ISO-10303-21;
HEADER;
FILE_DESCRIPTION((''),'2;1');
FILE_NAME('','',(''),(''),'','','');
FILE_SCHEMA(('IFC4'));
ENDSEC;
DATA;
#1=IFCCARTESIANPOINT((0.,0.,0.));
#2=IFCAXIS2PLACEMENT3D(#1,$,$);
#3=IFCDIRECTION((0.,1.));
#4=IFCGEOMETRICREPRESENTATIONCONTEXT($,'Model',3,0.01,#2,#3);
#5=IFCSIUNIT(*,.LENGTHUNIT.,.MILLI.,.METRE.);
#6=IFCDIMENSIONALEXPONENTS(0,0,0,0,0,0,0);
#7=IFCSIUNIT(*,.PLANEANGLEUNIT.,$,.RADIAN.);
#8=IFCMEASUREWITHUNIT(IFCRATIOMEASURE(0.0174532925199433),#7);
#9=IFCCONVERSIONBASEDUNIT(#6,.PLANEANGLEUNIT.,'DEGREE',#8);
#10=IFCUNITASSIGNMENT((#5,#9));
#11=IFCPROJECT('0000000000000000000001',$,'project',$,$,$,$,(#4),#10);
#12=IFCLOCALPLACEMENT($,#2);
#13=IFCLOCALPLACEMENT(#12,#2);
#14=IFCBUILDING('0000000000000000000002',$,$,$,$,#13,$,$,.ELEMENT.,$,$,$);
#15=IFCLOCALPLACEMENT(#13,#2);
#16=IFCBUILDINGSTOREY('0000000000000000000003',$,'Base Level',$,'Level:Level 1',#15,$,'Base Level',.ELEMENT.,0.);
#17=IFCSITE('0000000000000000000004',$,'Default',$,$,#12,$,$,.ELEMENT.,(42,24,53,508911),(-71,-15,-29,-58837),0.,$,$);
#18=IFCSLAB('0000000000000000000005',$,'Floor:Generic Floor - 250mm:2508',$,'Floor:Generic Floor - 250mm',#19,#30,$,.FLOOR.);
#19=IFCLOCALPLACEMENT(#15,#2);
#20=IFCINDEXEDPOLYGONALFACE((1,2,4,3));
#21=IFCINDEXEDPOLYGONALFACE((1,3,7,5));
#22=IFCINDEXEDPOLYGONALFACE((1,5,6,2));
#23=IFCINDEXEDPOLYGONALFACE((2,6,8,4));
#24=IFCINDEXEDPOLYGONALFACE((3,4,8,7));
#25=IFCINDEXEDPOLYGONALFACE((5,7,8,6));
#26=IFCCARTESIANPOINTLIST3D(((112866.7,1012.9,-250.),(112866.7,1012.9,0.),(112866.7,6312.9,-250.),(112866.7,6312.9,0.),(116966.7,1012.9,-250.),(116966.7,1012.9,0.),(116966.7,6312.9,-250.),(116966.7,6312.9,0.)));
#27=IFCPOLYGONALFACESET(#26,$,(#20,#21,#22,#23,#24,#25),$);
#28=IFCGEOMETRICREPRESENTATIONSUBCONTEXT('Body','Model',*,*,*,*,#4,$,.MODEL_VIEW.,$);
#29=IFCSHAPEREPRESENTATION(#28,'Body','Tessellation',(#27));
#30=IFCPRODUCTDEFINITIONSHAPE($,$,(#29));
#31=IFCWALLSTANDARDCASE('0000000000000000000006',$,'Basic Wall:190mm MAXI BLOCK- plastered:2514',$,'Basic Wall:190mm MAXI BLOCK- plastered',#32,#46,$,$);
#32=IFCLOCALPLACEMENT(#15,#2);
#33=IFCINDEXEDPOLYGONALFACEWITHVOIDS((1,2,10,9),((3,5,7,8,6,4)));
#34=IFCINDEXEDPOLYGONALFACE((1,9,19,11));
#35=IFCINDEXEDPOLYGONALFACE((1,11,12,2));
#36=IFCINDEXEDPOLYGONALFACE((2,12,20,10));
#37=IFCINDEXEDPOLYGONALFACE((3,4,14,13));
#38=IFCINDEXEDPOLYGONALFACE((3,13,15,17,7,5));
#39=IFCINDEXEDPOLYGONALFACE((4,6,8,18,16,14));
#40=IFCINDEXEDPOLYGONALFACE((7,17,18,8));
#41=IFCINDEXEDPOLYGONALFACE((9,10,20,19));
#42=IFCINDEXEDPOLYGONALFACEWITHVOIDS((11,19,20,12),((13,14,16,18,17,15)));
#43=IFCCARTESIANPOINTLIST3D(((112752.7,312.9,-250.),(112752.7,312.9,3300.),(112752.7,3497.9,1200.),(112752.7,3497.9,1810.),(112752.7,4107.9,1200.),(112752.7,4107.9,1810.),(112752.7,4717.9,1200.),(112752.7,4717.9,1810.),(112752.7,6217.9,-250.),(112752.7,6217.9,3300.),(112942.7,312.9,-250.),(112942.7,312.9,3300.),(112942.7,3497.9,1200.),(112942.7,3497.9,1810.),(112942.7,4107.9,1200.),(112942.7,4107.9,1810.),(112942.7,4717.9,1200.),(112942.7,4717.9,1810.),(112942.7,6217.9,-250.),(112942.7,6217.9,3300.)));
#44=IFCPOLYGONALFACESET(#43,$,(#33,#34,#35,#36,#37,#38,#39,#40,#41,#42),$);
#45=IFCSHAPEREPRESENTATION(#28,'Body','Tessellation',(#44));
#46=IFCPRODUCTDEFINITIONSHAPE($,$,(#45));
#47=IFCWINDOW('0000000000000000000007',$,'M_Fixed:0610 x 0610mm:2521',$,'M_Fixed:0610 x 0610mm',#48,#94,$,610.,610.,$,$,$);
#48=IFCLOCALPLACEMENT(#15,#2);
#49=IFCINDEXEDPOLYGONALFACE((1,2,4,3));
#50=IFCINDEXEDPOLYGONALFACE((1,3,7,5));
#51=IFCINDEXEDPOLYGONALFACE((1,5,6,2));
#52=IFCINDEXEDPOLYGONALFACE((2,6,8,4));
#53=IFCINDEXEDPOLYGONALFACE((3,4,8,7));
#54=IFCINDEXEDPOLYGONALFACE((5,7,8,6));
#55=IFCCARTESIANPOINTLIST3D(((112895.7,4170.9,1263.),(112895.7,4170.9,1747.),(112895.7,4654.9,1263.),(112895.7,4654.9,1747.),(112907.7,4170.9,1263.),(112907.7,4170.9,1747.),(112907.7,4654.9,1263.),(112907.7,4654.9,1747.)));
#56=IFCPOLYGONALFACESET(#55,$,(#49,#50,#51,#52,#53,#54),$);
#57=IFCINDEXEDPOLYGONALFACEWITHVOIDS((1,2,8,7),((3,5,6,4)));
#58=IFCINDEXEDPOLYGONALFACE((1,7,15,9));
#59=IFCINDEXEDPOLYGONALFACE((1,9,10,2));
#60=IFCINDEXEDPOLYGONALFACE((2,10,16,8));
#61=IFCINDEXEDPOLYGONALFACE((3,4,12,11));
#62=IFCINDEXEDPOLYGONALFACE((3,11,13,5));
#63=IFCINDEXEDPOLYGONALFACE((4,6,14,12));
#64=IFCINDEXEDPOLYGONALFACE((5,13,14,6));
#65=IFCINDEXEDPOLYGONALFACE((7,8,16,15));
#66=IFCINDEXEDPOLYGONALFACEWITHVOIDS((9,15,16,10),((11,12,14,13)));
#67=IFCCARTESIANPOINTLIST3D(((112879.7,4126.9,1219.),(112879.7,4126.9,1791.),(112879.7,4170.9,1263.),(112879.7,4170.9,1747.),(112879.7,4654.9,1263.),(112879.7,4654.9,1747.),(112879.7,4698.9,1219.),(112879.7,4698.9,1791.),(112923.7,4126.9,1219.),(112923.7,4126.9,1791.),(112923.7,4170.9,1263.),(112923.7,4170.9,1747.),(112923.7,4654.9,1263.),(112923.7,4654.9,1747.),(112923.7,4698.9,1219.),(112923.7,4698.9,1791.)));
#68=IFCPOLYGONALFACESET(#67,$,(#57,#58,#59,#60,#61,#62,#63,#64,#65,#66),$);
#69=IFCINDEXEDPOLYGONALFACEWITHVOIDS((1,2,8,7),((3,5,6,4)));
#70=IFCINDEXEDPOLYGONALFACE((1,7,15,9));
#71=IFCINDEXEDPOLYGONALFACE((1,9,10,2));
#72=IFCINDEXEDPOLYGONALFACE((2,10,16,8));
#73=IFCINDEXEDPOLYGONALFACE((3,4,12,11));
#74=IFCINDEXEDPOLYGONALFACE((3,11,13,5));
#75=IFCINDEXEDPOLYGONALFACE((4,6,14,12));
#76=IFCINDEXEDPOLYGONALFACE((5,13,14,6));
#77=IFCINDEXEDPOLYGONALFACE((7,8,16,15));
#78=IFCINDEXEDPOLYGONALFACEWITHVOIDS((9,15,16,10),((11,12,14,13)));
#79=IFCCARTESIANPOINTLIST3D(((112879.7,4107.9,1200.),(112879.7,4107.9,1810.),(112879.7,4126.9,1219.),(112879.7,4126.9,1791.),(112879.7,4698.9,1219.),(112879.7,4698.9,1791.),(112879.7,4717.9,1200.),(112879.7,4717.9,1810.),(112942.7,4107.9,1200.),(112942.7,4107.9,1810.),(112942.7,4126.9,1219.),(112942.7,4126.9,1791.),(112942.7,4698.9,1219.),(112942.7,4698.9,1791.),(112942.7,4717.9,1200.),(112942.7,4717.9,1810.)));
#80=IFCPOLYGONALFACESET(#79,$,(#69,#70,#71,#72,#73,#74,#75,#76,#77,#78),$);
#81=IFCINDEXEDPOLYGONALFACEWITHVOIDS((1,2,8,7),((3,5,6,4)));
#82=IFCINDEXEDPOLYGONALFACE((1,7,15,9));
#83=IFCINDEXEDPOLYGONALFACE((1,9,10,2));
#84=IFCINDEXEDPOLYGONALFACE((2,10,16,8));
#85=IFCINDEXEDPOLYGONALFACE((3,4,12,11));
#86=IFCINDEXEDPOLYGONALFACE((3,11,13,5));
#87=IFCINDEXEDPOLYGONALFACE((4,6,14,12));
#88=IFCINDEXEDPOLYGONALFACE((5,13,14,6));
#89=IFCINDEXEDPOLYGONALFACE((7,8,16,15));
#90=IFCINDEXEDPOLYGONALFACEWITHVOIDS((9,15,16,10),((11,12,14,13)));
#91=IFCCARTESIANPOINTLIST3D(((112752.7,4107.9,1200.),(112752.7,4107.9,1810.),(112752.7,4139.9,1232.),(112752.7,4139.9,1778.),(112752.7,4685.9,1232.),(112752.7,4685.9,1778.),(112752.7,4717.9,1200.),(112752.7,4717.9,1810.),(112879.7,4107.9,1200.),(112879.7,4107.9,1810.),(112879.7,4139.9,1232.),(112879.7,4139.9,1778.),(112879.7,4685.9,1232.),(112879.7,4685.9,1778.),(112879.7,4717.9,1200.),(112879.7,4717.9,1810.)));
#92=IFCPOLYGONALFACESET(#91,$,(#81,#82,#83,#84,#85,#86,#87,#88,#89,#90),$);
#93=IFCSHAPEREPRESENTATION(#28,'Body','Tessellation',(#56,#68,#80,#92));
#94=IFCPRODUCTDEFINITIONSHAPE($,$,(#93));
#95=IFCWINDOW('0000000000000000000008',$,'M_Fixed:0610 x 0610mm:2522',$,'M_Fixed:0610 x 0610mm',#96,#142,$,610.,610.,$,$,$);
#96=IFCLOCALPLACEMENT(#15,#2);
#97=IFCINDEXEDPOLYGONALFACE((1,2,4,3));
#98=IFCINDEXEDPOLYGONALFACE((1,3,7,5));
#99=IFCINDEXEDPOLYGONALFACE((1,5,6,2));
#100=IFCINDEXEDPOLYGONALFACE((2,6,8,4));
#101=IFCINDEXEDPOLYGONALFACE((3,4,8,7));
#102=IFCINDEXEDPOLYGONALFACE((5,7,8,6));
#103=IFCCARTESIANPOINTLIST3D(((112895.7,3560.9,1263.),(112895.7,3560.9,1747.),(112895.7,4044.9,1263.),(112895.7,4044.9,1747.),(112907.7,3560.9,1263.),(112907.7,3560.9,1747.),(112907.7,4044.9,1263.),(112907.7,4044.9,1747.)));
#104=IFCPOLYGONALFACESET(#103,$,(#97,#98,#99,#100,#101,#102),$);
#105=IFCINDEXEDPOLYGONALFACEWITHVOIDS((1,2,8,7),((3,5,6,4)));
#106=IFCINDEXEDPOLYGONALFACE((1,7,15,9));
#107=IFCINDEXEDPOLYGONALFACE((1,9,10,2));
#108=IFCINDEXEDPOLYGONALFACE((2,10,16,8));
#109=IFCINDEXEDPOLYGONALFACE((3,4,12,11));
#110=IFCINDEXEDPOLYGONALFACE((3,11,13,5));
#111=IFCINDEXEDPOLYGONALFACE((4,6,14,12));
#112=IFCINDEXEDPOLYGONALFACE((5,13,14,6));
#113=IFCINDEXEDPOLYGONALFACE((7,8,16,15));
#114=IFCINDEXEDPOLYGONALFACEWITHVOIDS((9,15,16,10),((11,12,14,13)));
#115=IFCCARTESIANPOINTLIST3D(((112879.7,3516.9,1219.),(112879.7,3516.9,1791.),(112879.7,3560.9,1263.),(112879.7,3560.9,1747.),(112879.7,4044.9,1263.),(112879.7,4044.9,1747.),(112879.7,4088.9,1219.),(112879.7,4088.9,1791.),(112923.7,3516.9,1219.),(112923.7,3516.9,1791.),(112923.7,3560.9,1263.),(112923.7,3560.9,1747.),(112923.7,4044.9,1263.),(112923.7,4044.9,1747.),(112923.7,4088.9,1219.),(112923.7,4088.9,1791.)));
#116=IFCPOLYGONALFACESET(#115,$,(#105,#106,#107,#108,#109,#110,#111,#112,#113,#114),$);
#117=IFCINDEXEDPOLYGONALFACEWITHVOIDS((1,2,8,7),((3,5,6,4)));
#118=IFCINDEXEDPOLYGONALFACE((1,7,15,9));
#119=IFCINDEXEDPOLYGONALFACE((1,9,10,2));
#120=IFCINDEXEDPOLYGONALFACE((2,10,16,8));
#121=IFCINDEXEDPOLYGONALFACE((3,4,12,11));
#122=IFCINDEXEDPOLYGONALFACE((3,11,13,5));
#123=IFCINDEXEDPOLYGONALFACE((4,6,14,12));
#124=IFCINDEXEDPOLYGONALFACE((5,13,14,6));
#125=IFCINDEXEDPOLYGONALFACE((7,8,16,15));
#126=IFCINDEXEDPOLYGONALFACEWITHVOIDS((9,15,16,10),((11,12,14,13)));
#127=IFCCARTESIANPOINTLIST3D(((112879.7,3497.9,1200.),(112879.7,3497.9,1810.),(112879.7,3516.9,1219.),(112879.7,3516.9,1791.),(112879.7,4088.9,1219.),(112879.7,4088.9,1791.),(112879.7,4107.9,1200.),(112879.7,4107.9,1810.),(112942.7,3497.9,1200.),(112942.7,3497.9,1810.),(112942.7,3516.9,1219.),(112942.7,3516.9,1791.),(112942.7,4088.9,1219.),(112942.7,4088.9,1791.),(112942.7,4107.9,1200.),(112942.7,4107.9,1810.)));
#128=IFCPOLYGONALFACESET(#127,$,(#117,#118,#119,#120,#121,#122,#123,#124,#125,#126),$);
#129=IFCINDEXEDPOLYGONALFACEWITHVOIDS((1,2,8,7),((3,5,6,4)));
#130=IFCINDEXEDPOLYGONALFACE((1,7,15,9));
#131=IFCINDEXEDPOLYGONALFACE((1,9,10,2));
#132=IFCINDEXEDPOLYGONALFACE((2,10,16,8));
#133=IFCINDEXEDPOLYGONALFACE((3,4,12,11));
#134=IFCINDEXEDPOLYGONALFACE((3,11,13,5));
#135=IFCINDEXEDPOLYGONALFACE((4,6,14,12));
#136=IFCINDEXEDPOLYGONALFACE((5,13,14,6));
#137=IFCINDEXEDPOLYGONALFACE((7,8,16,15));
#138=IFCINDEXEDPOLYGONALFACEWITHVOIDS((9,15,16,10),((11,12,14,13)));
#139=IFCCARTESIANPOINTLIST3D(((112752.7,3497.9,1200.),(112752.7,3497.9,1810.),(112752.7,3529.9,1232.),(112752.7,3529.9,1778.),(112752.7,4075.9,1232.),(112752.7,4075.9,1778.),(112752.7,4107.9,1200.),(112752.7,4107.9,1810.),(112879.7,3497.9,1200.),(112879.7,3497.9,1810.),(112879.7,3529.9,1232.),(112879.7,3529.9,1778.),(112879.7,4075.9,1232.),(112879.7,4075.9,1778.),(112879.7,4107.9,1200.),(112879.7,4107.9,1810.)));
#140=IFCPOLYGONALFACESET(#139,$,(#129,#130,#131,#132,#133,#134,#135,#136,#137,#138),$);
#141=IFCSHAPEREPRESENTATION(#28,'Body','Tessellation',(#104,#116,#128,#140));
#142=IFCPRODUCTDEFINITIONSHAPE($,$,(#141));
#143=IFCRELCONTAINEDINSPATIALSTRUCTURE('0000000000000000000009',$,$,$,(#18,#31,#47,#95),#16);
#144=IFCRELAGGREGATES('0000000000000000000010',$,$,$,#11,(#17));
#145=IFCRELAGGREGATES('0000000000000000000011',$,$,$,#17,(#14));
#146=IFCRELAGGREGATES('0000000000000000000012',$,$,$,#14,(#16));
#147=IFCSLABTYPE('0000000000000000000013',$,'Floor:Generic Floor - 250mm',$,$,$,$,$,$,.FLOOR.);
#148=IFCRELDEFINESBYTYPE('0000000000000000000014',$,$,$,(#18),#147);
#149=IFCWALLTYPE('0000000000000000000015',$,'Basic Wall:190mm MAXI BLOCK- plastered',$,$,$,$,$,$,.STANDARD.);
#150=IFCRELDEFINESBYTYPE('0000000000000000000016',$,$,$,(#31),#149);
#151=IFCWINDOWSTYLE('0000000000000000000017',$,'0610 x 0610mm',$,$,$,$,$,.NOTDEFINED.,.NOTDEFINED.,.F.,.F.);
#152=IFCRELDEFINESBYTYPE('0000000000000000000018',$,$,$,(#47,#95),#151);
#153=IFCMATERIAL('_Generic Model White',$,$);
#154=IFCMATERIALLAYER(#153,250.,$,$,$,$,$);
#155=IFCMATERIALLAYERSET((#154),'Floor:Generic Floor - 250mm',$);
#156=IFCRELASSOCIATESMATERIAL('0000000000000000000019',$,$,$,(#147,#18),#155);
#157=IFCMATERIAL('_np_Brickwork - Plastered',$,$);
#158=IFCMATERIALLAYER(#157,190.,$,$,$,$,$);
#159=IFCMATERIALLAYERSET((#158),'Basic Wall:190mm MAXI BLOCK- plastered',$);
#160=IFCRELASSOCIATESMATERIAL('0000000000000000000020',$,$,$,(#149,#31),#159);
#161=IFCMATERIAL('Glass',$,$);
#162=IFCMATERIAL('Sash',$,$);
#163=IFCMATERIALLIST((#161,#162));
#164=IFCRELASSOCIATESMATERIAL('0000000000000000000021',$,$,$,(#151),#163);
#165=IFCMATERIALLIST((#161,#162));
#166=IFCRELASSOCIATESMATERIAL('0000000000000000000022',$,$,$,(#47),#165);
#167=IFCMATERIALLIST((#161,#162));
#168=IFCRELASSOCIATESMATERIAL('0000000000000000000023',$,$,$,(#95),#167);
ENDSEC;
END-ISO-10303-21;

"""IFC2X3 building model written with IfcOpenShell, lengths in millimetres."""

from ifc_helpers import new_model, entity, si_unit, converted_unit, direction, frame, frame_2d, origin, origin_2d_with_axis, place, context, subcontext, project, spatial, polyline, rectangle, outline, extrude, source, transform, mapped, material, material_list, layer, layer_set, layer_usage, type_object, type_shapes, element, fill, save


model = new_model("IFC2X3")

# Units and contexts
model_context = context("Model", 3, precision=0.01, world=origin(), true_north=direction((0.0, 1.0)))
body_context = subcontext(model_context, "Body", "Model", "MODEL_VIEW")
ifc_project = project(units=[si_unit("LENGTHUNIT", "METRE", prefix="MILLI"), converted_unit("PLANEANGLEUNIT", "DEGREE", entity("IfcRatioMeasure", 0.0174532925199433), si_unit("PLANEANGLEUNIT", "RADIAN"), dimensions=[0, 0, 0, 0, 0, 0, 0])], contexts=[model_context])

# Site, building, storey
site_placement = place(None, origin())
site = spatial("IfcSite", under=ifc_project, at=site_placement, Name="Default", CompositionType="ELEMENT", RefLatitude=(42, 24, 53, 508911), RefLongitude=(-71, -15, -29, -58837), RefElevation=0.0)
building_placement = place(site_placement, origin())
building = spatial("IfcBuilding", under=site, at=building_placement, CompositionType="ELEMENT")
storey_placement = place(building_placement, origin())
storey = spatial("IfcBuildingStorey", under=building, at=storey_placement, Name="Base Level", ObjectType="Level:Level 1", LongName="Base Level", CompositionType="ELEMENT", Elevation=0.0)

# Slab
ifc_material_1 = material(Name="_Generic Model White")
ifc_layer_1 = layer(ifc_material_1, 250.0)
ifc_layer_set_1 = layer_set([ifc_layer_1], Name="Floor:Generic Floor - 250mm")
ifc_layer_usage_1 = layer_usage(ifc_layer_set_1, "AXIS3", "POSITIVE", 0.0)
slab_type = type_object("IfcSlabType", Name="Floor:Generic Floor - 250mm", PredefinedType="FLOOR", material=ifc_layer_set_1)
slab_placement = place(building_placement, origin())
element("IfcSlab", 1, at=slab_placement, inside=storey, type_object=slab_type, material=ifc_layer_usage_1, Name="Floor:Generic Floor - 250mm:2508", ObjectType="Floor:Generic Floor - 250mm", PredefinedType="FLOOR", context=body_context, shape_type="SweptSolid", body=[
    extrude(rectangle(XDim=5300.0, YDim=4100.0, at=origin_2d_with_axis()), frame((114916.7, 3662.9, 0.0), z_axis=(0.0, 0.0, -1.0), x_axis=(0.0, 1.0, 0.0)), (0.0, 0.0, 1.0), 250.0),
])

# Wall, openings, windows
ifc_material_2 = material(Name="_np_Brickwork - Plastered")
ifc_layer_2 = layer(ifc_material_2, 190.0)
ifc_layer_set_2 = layer_set([ifc_layer_2], Name="Basic Wall:190mm MAXI BLOCK- plastered")
ifc_layer_usage_2 = layer_usage(ifc_layer_set_2, "AXIS2", "NEGATIVE", 95.0)
wall_type = type_object("IfcWallType", Name="Basic Wall:190mm MAXI BLOCK- plastered", PredefinedType="STANDARD", material=ifc_layer_set_2)
wall_placement = place(building_placement, frame((112847.7, 312.9, -250.0), z_axis=(0.0, 0.0, 1.0), x_axis=(0.0, 1.0, 0.0)))
wall = element("IfcWallStandardCase", 2, at=wall_placement, inside=storey, type_object=wall_type, material=ifc_layer_usage_2, Name="Basic Wall:190mm MAXI BLOCK- plastered:2514", ObjectType="Basic Wall:190mm MAXI BLOCK- plastered", context=body_context, shape_type="SweptSolid", body=[
    extrude(rectangle(XDim=5905.0, YDim=190.0, at=frame_2d((2952.5, 0.0), x_axis=(-1.0, 0.0))), origin(), (0.0, 0.0, 1.0), 3550.0),
])
opening_1_placement = place(wall_placement, frame((4405.0, 95.0, 1450.0)))
opening_1 = element("IfcOpeningElement", 3, at=opening_1_placement, cuts=wall, ObjectType="Opening", context=body_context, shape_type="SweptSolid", body=[
    extrude(rectangle(XDim=610.0, YDim=610.0, at=frame_2d((305.0, 305.0), x_axis=(1.0, 0.0))), frame((0.0, 0.0, 0.0), z_axis=(0.0, -1.0, 0.0), x_axis=(0.0, 0.0, 1.0)), (0.0, 0.0, 1.0), 190.0),
])
opening_2_placement = place(wall_placement, frame((3795.0, 95.0, 1450.0)))
opening_2 = element("IfcOpeningElement", 4, at=opening_2_placement, cuts=wall, ObjectType="Opening", context=body_context, shape_type="SweptSolid", body=[
    extrude(rectangle(XDim=610.0, YDim=610.0, at=frame_2d((305.0, 305.0), x_axis=(1.0, 0.0))), frame((0.0, 0.0, 0.0), z_axis=(0.0, -1.0, 0.0), x_axis=(0.0, 0.0, 1.0)), (0.0, 0.0, 1.0), 190.0),
])
ifc_material_3 = material(Name="Glass")
ifc_material_4 = material(Name="Sash")
ifc_material_list_1 = material_list([ifc_material_3, ifc_material_4])
ifc_material_list_2 = material_list([ifc_material_3, ifc_material_4])
window_style = type_object("IfcWindowStyle", Name="0610 x 0610mm", ConstructionType="NOTDEFINED", OperationType="NOTDEFINED", ParameterTakesPrecedence=False, Sizeable=False, material=ifc_material_list_2)
shared_shape_1 = source(origin(), body_context, "Body", "SweptSolid", [
    extrude(rectangle(XDim=12.0, YDim=484.0, at=frame_2d((0.0, 0.0), x_axis=(1.0, 0.0))), frame((305.0, 149.0, 63.0), z_axis=(0.0, 0.0, 1.0), x_axis=(0.0, -1.0, 0.0)), (0.0, 0.0, 1.0), 484.0),
    extrude(outline(polyline([(-286.0, -286.0), (286.0, -286.0), (286.0, 286.0), (-286.0, 286.0), (-286.0, -286.0)]), holes=[polyline([(-242.0, -242.0), (-242.0, 242.0), (242.0, 242.0), (242.0, -242.0), (-242.0, -242.0)])]), frame((305.0, 127.0, 305.0), z_axis=(0.0, 1.0, 0.0), x_axis=(1.0, 0.0, 0.0)), (0.0, 0.0, 1.0), 44.0),
    extrude(outline(polyline([(-305.0, -305.0), (305.0, -305.0), (305.0, 305.0), (-305.0, 305.0), (-305.0, -305.0)]), holes=[polyline([(-286.0, -286.0), (-286.0, 286.0), (286.0, 286.0), (286.0, -286.0), (-286.0, -286.0)])]), frame((305.0, 127.0, 305.0), z_axis=(0.0, 1.0, 0.0), x_axis=(1.0, 0.0, 0.0)), (0.0, 0.0, 1.0), 63.0),
    extrude(outline(polyline([(-305.0, -305.0), (305.0, -305.0), (305.0, 305.0), (-305.0, 305.0), (-305.0, -305.0)]), holes=[polyline([(-273.0, -273.0), (-273.0, 273.0), (273.0, 273.0), (273.0, -273.0), (-273.0, -273.0)])]), frame((305.0, 0.0, 305.0), z_axis=(0.0, 1.0, 0.0), x_axis=(1.0, 0.0, 0.0)), (0.0, 0.0, 1.0), 127.0),
])
type_shapes(window_style, [shared_shape_1])
window_1_placement = place(opening_1_placement, frame((0.0, 0.0, 0.0), z_axis=(0.0, 0.0, 1.0), x_axis=(-1.0, 0.0, 0.0)))
window_1 = element("IfcWindow", 5, at=window_1_placement, inside=storey, type_object=window_style, material=ifc_material_list_1, Name="M_Fixed:0610 x 0610mm:2521", ObjectType="M_Fixed:0610 x 0610mm", OverallHeight=610.0, OverallWidth=610.0, context=body_context, shape_type="MappedRepresentation", body=[
    mapped(shared_shape_1, transform((0.0, 0.0, 0.0), scale=1.0)),
])
fill(opening_1, window_1)
ifc_material_list_3 = material_list([ifc_material_3, ifc_material_4])
window_2_placement = place(opening_2_placement, frame((0.0, 0.0, 0.0), z_axis=(0.0, 0.0, 1.0), x_axis=(-1.0, 0.0, 0.0)))
window_2 = element("IfcWindow", 6, at=window_2_placement, inside=storey, type_object=window_style, material=ifc_material_list_3, Name="M_Fixed:0610 x 0610mm:2522", ObjectType="M_Fixed:0610 x 0610mm", OverallHeight=610.0, OverallWidth=610.0, context=body_context, shape_type="MappedRepresentation", body=[
    mapped(shared_shape_1, transform((0.0, 0.0, 0.0), scale=1.0)),
])
fill(opening_2, window_2)

save(model, "model.ifc")
